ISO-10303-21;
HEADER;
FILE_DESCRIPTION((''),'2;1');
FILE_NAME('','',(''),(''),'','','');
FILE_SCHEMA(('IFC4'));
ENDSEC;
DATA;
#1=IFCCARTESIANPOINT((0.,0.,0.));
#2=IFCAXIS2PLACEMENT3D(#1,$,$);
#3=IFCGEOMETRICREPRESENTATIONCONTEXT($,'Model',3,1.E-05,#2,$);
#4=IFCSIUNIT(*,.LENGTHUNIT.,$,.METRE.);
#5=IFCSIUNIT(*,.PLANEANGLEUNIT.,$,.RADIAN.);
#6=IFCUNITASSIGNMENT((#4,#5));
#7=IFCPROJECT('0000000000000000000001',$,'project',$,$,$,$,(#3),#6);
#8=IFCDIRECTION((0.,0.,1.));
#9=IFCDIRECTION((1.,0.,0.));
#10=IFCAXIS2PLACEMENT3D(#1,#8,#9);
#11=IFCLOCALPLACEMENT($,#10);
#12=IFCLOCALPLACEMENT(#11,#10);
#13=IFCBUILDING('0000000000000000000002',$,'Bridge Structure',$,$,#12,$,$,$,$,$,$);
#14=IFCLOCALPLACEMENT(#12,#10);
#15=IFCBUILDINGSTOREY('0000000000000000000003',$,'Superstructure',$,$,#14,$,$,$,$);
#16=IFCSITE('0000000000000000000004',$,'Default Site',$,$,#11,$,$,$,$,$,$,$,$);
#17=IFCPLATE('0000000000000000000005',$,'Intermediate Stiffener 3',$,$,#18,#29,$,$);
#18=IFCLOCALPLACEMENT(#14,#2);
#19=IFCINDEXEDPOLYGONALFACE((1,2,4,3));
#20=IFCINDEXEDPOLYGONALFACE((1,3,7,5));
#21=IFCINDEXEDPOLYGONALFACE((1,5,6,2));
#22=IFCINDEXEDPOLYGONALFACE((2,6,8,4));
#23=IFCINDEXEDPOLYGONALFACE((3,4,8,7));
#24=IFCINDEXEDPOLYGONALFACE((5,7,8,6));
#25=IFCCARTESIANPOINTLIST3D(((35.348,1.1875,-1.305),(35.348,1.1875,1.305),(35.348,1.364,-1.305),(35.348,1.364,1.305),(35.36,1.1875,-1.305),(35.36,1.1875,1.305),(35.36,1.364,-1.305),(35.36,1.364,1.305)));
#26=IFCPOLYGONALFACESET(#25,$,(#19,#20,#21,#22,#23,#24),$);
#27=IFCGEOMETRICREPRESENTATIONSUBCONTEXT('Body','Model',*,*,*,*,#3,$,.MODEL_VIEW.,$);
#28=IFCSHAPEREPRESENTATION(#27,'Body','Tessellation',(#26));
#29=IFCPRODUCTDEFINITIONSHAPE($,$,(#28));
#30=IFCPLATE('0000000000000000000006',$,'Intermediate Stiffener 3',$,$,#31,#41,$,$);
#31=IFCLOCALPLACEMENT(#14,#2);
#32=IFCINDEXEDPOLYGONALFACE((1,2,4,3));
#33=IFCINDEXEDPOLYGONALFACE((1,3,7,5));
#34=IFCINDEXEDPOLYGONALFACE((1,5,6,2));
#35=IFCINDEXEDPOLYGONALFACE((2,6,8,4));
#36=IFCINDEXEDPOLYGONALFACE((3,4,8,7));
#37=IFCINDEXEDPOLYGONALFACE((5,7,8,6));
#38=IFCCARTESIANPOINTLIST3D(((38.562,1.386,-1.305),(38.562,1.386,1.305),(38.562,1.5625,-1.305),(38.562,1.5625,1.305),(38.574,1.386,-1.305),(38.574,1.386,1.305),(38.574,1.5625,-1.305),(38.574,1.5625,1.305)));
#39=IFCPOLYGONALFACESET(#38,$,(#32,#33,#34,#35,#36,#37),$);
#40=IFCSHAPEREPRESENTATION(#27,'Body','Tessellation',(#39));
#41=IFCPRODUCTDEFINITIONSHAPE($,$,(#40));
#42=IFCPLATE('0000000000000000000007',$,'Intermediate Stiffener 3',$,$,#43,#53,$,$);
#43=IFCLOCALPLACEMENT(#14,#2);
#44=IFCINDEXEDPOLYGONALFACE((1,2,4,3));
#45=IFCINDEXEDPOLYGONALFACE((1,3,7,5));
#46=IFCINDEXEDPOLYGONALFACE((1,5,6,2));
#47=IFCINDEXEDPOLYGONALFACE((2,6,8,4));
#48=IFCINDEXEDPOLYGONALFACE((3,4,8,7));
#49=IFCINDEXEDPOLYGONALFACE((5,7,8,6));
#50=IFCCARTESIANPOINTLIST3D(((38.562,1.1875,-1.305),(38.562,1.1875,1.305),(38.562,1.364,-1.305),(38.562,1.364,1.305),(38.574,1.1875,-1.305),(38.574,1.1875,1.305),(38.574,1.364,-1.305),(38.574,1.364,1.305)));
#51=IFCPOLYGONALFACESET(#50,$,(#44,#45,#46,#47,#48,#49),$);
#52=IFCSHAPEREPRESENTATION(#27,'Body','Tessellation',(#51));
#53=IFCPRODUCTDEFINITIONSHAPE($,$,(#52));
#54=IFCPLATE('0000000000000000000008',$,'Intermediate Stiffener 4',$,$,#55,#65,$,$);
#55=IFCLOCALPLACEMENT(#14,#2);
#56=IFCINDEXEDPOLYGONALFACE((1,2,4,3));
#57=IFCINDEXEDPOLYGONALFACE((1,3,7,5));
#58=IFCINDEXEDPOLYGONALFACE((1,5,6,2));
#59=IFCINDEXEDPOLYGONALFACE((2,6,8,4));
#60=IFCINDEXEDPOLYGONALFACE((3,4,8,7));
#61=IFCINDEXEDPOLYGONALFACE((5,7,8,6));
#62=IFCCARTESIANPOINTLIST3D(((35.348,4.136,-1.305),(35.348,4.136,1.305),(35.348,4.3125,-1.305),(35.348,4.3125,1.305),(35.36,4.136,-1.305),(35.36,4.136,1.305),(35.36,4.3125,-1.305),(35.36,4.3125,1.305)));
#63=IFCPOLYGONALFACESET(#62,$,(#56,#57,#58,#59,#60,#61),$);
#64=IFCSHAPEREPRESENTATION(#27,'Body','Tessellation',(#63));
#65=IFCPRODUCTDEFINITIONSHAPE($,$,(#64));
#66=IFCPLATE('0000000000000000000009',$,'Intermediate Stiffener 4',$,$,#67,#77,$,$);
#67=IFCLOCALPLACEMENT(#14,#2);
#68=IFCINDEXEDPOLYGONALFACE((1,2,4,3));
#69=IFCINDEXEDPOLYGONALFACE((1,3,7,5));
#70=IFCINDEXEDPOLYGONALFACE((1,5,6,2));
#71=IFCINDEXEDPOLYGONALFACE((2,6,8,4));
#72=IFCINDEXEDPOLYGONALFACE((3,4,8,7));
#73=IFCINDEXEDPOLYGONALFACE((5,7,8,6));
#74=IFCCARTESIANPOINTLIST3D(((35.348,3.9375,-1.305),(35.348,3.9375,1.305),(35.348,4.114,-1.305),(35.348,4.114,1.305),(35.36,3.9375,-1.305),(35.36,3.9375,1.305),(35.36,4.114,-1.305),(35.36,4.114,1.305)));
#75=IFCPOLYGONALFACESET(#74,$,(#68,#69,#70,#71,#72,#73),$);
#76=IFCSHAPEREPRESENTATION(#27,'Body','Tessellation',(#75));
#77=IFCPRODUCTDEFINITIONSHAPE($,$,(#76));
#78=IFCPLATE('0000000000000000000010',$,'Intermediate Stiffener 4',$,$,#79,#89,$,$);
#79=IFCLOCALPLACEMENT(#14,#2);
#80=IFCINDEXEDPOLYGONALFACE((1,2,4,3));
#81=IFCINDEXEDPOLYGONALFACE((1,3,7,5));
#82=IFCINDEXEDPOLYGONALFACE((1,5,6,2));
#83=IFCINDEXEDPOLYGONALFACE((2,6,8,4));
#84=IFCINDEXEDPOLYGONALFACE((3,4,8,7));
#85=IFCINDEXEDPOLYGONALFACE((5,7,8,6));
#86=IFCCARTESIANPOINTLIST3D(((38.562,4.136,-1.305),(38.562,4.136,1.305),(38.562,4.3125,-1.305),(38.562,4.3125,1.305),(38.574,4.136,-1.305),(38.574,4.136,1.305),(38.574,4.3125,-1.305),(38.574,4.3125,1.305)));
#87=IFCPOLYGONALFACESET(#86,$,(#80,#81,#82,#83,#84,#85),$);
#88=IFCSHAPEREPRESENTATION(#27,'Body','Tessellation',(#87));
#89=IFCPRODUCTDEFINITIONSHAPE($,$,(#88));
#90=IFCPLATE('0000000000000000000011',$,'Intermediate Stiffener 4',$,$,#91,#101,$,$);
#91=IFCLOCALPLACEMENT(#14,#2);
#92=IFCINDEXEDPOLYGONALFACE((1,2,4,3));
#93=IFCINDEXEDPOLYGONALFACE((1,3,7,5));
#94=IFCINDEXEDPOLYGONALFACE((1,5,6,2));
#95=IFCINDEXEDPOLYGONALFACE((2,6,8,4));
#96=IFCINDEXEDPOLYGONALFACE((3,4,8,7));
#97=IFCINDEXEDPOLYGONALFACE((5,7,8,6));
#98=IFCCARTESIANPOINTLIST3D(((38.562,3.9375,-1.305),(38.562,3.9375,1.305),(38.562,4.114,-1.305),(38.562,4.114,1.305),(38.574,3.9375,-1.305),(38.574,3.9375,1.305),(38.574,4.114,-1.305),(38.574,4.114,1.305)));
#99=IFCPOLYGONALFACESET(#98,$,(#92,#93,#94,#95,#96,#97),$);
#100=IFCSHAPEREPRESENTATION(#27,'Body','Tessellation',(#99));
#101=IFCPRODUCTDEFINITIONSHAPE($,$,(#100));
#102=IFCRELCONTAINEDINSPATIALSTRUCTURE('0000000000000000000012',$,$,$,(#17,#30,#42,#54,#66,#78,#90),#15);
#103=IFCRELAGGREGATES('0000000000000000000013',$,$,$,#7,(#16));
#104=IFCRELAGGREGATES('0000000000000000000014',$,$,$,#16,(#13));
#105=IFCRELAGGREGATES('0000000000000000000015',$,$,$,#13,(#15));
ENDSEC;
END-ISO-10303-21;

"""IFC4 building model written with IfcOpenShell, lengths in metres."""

from ifc_helpers import new_model, si_unit, frame, origin, origin_with_axes, origin_2d_with_axis, place, context, subcontext, project, spatial, rectangle, extrude, element, save


model = new_model("IFC4")

# Units and contexts
model_context = context("Model", 3, precision=1e-05, world=origin())
body_context = subcontext(model_context, "Body", "Model", "MODEL_VIEW")
ifc_project = project(units=[si_unit("LENGTHUNIT", "METRE"), si_unit("PLANEANGLEUNIT", "RADIAN")], contexts=[model_context])

# Site, building, storey
site_placement = place(None, origin_with_axes())
site = spatial("IfcSite", under=ifc_project, at=site_placement, Name="Default Site")
building_placement = place(site_placement, origin_with_axes())
building = spatial("IfcBuilding", under=site, at=building_placement, Name="Bridge Structure")
storey_placement = place(building_placement, origin_with_axes())
storey = spatial("IfcBuildingStorey", under=building, at=storey_placement, Name="Superstructure")

# Plates
for number, where, z_axis, x_axis, name in (
    (1, (35.354, 1.2757, -1.305), (0.0, 0.0, 1.0), (1.0, 0.0, 0.0), "Intermediate Stiffener 3"),
    (2, (38.568, 1.4743, -1.305), (0.0, 0.0, 1.0), (1.0, 0.0, 0.0), "Intermediate Stiffener 3"),
    (3, (38.568, 1.2757, -1.305), (0.0, 0.0, 1.0), (1.0, 0.0, 0.0), "Intermediate Stiffener 3"),
    (4, (35.354, 4.2243, -1.305), (0.0, 0.0, 1.0), (1.0, 0.0, 0.0), "Intermediate Stiffener 4"),
    (5, (35.354, 4.0258, -1.305), (0.0, 0.0, 1.0), (1.0, 0.0, 0.0), "Intermediate Stiffener 4"),
    (6, (38.568, 4.2243, -1.305), (0.0, 0.0, 1.0), (1.0, 0.0, 0.0), "Intermediate Stiffener 4"),
    (7, (38.568, 4.0258, -1.305), (0.0, 0.0, 1.0), (1.0, 0.0, 0.0), "Intermediate Stiffener 4"),
):
    element("IfcPlate", number, at=place(storey_placement, frame(where, z_axis=z_axis, x_axis=x_axis)), inside=storey, Name=name, context=body_context, shape_type="SweptSolid", body=[
        extrude(rectangle(XDim=0.012, YDim=0.1765, at=origin_2d_with_axis()), origin_with_axes(), (0.0, 0.0, 1.0), 2.61),
    ])

save(model, "model.ifc")
